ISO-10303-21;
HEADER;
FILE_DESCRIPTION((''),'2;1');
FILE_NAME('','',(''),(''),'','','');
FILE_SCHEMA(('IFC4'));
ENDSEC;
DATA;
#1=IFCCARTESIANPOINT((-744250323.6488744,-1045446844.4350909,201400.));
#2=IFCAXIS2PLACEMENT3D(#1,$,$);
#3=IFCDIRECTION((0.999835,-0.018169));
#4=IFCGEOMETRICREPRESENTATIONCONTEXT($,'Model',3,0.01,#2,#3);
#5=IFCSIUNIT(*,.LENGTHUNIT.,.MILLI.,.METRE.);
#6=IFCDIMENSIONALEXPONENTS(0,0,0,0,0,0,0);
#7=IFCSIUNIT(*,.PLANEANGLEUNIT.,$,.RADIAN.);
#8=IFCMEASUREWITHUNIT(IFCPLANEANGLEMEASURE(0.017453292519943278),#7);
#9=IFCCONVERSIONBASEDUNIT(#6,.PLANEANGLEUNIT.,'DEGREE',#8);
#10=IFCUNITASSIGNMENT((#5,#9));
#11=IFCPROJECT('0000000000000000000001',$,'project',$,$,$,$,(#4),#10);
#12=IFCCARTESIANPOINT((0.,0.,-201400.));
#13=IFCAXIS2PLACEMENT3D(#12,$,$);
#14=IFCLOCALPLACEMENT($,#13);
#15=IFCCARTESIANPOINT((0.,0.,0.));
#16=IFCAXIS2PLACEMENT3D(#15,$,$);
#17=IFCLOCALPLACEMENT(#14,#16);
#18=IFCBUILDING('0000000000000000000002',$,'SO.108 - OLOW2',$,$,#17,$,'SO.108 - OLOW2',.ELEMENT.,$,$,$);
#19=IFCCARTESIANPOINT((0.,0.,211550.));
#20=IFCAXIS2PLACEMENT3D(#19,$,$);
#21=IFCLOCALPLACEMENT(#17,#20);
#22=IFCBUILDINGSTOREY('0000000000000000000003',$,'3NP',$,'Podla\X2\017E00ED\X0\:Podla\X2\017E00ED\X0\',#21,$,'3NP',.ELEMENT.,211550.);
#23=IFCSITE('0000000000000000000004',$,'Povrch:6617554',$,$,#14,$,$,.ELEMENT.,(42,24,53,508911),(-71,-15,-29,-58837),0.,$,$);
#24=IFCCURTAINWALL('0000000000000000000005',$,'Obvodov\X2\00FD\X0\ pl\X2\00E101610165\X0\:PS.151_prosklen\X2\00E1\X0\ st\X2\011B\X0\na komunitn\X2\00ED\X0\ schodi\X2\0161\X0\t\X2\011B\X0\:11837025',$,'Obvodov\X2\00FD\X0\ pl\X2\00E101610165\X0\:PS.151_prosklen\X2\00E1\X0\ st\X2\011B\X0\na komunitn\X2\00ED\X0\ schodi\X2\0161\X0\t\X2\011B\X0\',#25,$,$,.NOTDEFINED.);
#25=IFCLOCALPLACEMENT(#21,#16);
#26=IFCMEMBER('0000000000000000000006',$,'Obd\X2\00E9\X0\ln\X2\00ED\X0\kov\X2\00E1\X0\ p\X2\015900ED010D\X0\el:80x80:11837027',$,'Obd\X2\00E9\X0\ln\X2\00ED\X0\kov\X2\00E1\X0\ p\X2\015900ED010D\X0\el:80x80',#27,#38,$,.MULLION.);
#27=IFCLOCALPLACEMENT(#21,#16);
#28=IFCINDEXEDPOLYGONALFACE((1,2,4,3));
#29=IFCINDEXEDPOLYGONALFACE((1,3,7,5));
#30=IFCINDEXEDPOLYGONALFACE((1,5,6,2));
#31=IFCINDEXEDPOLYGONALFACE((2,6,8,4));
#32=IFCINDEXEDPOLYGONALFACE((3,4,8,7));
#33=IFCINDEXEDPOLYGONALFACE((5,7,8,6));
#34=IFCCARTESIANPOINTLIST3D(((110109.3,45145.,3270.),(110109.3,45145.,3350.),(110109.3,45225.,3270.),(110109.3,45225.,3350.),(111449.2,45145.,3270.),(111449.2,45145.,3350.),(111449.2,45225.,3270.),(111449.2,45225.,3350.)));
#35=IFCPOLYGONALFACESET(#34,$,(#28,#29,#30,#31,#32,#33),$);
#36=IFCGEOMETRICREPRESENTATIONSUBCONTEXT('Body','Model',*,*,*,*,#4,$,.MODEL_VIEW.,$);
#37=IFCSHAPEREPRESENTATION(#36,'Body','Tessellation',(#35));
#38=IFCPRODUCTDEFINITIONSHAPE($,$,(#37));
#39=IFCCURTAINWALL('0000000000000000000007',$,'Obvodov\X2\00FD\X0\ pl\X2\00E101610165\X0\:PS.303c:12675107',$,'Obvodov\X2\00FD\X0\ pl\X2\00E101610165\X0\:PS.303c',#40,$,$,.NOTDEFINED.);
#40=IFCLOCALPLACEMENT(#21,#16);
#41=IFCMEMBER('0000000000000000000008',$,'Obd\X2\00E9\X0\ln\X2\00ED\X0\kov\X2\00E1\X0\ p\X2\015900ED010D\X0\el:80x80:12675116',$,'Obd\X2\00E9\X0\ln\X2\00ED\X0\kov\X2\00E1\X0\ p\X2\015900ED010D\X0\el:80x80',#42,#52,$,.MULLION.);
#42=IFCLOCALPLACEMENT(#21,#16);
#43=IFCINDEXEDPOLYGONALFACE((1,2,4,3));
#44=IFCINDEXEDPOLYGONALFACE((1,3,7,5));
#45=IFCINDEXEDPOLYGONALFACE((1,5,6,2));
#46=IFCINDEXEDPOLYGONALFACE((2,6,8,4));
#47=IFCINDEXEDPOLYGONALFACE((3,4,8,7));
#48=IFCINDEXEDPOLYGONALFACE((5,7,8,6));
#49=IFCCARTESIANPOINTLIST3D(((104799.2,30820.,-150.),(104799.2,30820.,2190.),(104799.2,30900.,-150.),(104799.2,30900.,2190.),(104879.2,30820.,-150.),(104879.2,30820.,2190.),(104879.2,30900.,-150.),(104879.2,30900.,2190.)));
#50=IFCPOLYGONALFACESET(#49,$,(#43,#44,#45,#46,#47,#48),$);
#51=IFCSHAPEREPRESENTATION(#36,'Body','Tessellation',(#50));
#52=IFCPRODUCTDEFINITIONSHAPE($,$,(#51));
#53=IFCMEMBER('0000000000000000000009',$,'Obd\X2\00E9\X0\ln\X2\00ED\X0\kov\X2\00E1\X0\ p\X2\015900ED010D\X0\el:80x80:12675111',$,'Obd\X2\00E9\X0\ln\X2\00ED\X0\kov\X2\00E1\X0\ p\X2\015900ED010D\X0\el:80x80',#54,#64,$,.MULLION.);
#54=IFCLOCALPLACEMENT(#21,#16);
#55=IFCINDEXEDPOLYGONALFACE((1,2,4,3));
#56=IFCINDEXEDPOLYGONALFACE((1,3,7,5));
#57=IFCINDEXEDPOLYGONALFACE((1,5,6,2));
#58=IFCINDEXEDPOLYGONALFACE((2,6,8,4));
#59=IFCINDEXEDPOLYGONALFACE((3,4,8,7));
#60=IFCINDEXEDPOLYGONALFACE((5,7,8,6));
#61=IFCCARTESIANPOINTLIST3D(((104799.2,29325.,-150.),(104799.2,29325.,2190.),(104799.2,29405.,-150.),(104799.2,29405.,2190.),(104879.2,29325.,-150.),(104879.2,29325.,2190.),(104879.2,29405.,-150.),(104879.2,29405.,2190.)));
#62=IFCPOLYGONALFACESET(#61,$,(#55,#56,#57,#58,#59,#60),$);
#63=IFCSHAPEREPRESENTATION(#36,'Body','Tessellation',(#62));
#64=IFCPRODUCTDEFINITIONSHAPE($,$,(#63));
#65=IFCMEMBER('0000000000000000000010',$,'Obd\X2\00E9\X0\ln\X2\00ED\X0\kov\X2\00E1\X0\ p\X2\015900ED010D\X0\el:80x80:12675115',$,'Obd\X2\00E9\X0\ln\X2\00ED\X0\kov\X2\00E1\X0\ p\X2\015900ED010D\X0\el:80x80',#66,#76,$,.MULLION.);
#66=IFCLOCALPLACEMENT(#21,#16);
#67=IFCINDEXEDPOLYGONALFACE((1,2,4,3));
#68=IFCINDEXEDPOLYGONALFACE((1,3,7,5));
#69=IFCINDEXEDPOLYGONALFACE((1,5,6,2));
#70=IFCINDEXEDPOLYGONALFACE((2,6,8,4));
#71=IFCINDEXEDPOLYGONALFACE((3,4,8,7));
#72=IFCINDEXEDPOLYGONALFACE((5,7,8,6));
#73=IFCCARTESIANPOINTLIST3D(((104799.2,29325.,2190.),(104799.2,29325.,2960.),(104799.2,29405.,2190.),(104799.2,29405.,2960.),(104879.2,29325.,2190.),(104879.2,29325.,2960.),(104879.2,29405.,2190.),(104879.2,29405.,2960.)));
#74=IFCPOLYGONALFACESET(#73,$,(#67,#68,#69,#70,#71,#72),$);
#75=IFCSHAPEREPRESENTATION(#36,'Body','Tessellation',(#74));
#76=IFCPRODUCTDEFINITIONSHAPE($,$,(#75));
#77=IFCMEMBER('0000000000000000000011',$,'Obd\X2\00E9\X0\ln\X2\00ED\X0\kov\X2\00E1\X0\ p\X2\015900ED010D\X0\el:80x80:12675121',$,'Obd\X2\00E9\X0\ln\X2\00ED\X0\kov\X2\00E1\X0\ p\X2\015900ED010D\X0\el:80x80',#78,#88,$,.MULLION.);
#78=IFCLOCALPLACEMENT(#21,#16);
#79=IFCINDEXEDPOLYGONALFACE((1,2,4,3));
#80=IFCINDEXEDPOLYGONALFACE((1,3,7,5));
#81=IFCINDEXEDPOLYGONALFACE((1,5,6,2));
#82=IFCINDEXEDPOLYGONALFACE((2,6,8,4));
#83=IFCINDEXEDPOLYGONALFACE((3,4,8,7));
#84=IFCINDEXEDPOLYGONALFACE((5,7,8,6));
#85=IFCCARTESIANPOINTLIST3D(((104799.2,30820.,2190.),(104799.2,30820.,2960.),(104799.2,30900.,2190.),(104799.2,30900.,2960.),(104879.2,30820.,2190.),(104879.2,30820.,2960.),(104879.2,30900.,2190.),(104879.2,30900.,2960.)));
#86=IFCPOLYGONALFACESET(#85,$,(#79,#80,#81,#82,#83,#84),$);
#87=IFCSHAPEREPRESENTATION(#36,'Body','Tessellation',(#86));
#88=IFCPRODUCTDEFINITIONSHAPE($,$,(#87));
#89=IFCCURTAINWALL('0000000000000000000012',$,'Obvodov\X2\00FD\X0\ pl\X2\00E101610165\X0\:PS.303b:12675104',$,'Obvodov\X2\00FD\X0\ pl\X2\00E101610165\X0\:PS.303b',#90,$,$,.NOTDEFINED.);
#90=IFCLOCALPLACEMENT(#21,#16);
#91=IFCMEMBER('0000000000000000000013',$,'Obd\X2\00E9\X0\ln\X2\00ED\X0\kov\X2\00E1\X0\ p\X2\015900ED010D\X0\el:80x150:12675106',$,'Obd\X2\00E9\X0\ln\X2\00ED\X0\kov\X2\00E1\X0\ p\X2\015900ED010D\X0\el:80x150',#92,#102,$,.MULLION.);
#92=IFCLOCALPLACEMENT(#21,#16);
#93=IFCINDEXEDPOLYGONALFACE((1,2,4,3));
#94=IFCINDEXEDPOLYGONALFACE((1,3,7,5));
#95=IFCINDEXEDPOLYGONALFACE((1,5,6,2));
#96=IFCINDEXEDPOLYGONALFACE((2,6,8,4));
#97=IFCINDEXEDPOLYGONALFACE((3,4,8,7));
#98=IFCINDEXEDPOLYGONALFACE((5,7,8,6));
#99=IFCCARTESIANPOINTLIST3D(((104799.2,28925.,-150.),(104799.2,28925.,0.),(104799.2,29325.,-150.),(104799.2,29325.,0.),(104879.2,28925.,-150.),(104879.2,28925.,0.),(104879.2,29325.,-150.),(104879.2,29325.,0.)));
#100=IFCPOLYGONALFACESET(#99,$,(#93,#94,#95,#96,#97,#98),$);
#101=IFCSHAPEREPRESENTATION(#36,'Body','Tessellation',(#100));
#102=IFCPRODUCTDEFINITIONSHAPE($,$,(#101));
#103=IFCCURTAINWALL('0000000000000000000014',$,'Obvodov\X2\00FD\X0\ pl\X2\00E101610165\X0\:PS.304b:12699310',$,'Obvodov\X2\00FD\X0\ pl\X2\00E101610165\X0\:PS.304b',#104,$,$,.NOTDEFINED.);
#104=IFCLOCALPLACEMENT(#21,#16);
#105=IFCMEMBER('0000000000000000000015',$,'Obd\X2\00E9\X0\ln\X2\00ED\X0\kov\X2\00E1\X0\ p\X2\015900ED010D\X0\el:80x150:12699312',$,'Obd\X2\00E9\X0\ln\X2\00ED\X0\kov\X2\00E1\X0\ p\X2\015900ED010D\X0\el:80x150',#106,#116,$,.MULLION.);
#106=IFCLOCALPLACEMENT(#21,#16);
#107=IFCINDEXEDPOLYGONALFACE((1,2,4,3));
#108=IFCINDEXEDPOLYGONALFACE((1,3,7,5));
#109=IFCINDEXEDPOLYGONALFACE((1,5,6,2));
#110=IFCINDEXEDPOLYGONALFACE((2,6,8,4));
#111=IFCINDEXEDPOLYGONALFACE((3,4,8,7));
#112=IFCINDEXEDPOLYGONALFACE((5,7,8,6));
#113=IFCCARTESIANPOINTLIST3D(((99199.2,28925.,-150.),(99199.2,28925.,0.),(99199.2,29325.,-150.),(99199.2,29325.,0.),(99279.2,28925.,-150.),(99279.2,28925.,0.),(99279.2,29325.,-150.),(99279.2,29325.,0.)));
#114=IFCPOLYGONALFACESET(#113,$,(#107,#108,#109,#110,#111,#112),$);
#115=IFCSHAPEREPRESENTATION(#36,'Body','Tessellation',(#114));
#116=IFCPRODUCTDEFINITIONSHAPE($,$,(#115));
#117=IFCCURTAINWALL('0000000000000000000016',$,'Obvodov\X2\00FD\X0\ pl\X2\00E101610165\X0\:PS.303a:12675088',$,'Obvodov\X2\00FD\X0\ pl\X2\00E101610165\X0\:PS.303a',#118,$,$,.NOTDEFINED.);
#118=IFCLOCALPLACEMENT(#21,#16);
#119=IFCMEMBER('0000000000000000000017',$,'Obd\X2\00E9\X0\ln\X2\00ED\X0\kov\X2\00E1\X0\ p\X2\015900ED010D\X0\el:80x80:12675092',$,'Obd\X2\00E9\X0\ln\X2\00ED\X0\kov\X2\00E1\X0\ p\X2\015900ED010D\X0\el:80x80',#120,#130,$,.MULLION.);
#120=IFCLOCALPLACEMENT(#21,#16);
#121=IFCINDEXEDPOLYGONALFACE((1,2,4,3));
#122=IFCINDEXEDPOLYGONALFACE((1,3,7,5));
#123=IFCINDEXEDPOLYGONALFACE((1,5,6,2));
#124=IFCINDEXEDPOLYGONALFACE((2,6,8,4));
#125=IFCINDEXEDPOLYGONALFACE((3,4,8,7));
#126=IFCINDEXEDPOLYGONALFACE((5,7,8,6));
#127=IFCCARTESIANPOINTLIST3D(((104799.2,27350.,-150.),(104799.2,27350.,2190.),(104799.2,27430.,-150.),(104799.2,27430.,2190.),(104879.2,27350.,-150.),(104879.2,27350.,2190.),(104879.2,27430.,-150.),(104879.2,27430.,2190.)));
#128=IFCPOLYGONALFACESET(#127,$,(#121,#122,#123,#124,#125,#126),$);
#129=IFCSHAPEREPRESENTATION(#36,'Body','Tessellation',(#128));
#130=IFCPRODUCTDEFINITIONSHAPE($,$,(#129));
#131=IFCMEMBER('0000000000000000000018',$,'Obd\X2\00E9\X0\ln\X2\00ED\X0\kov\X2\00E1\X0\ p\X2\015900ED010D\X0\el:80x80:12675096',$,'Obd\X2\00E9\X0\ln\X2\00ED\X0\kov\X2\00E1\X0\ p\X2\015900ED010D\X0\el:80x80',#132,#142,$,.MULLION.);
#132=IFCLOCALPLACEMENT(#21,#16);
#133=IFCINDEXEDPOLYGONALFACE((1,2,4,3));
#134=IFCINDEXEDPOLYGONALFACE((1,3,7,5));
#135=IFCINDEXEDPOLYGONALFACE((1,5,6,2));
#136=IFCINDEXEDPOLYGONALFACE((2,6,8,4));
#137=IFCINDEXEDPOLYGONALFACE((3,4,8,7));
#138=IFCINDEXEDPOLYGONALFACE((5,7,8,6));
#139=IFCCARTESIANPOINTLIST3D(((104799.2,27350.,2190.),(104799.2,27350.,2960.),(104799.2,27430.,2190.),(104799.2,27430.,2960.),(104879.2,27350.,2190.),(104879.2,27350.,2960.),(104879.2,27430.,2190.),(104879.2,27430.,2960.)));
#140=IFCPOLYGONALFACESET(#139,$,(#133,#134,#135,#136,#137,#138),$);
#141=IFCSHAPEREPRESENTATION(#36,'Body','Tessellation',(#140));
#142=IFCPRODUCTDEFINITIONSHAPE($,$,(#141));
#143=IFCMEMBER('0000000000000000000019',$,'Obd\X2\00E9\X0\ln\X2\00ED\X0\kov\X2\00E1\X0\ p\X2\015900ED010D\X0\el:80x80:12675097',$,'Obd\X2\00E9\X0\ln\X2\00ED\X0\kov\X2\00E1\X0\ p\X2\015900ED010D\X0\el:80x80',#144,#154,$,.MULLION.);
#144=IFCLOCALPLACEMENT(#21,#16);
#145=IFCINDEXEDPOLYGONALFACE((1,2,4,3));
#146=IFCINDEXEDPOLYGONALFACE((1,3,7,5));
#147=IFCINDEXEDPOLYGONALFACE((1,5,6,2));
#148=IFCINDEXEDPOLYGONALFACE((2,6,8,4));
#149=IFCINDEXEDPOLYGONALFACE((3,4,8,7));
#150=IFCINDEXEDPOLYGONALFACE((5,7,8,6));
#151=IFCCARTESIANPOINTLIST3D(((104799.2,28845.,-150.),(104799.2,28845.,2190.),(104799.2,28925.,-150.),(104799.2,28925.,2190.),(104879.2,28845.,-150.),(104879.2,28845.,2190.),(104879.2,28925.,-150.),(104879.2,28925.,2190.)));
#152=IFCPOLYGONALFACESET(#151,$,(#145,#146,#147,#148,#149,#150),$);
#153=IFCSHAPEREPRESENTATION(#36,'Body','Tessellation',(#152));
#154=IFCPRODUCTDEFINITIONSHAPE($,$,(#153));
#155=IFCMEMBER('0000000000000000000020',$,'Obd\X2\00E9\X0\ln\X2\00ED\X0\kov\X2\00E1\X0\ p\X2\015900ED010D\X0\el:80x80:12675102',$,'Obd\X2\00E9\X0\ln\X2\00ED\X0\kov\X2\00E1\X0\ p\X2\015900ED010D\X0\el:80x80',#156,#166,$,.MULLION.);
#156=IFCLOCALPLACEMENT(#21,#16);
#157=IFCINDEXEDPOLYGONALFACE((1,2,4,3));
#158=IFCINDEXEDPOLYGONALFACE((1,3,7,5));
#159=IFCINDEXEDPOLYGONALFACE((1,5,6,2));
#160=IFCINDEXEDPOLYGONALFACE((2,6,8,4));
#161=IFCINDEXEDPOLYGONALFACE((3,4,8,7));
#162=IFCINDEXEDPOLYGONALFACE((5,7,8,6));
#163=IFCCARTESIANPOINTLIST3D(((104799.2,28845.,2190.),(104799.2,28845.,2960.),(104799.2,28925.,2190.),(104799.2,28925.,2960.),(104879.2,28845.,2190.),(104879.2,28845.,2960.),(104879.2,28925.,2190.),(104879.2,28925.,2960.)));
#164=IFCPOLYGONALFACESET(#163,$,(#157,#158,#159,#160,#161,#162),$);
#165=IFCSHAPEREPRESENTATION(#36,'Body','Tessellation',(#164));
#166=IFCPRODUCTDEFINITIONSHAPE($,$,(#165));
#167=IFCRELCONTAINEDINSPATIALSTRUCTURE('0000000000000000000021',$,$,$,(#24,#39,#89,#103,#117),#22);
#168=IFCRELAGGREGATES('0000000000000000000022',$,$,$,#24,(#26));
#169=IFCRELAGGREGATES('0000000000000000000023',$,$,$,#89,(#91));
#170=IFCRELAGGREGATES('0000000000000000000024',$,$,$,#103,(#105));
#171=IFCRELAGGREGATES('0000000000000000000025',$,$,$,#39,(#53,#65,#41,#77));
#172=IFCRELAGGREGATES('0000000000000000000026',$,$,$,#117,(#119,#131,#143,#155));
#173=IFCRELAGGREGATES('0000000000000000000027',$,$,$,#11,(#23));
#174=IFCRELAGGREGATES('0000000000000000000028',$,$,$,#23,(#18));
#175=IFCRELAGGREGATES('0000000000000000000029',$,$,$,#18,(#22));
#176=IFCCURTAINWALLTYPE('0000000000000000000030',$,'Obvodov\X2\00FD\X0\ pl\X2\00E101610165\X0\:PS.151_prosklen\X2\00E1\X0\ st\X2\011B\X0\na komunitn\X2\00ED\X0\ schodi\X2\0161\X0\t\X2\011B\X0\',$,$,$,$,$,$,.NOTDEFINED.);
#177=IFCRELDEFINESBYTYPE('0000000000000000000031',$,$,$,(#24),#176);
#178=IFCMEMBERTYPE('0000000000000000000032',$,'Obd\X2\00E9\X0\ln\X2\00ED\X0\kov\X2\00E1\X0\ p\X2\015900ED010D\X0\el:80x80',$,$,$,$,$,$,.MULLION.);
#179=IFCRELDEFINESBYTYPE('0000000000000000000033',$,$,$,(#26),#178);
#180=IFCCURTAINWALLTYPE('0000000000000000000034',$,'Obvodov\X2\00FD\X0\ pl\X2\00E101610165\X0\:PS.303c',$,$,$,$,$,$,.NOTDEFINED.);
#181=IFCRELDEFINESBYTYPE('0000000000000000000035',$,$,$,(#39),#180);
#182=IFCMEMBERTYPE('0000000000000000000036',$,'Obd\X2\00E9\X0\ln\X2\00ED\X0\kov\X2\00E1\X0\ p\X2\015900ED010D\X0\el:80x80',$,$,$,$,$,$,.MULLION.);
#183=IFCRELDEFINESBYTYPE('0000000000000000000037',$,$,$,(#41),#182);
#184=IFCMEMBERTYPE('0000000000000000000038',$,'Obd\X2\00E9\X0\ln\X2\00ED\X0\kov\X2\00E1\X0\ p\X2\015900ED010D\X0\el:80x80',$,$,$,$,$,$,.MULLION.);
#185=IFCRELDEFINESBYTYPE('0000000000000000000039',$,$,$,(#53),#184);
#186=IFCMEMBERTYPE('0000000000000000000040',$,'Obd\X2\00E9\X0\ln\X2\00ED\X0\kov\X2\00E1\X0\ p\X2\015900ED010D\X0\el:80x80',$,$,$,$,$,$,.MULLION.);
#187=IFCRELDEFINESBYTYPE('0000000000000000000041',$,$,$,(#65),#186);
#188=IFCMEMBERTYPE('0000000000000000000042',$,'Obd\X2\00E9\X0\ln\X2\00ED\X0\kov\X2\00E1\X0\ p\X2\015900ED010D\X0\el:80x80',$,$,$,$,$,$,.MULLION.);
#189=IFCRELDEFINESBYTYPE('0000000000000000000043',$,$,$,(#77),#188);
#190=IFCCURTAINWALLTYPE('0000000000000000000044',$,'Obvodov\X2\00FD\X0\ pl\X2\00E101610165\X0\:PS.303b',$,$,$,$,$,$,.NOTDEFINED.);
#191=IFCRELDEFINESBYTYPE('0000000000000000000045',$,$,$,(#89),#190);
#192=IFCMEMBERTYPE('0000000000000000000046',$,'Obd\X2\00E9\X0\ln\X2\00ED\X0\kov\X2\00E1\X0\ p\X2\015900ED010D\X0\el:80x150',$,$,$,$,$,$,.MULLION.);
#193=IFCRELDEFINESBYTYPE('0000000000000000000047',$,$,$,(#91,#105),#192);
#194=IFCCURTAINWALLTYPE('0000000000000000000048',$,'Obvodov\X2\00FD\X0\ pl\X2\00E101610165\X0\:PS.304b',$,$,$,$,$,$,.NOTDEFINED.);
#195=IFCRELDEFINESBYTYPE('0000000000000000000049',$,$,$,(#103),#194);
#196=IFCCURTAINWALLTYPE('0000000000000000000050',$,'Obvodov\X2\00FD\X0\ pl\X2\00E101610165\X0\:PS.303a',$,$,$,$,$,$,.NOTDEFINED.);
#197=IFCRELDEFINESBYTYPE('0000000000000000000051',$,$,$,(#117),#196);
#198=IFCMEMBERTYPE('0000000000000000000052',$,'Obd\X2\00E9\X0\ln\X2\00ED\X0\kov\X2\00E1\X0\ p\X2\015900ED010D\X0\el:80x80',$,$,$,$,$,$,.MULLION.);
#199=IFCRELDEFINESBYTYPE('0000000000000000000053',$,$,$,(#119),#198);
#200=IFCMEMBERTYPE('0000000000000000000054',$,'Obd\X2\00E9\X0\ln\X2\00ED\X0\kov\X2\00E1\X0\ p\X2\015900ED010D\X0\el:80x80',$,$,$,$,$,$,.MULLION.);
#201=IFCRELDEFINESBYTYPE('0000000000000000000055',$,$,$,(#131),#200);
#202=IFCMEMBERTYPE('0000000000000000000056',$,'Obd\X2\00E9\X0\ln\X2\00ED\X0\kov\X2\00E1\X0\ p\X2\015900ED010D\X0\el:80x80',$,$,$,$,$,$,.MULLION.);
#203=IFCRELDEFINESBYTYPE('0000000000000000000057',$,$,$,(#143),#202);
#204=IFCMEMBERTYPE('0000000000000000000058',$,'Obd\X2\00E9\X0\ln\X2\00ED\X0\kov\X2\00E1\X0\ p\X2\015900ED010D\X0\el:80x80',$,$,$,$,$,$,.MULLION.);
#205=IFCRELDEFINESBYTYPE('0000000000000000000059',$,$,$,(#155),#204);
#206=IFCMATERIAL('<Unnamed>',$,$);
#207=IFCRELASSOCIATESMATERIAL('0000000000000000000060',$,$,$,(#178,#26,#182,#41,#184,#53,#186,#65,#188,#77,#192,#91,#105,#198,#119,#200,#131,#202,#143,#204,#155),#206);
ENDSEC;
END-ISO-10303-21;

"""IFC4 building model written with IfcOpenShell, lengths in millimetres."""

from ifc_helpers import new_model, entity, si_unit, converted_unit, direction, frame, origin, place, context, subcontext, project, spatial, indexed_curve, outline, extrude, source, transform, mapped, material, type_object, type_shapes, element, aggregate, save


model = new_model("IFC4")

# Units and contexts
model_context = context("Model", 3, precision=0.01, world=frame((-744250323.6488744, -1045446844.4350909, 201400.0)), true_north=direction((0.999835, -0.018169)))
body_context = subcontext(model_context, "Body", "Model", "MODEL_VIEW")
ifc_project = project(units=[si_unit("LENGTHUNIT", "METRE", prefix="MILLI"), converted_unit("PLANEANGLEUNIT", "DEGREE", entity("IfcPlaneAngleMeasure", 0.017453292519943278), si_unit("PLANEANGLEUNIT", "RADIAN"), dimensions=[0, 0, 0, 0, 0, 0, 0])], contexts=[model_context])

# Site, building, storey
site_placement = place(None, frame((0.0, 0.0, -201400.0)))
site = spatial("IfcSite", under=ifc_project, at=site_placement, Name="Povrch:6617554", CompositionType="ELEMENT", RefLatitude=(42, 24, 53, 508911), RefLongitude=(-71, -15, -29, -58837), RefElevation=0.0)
building_placement = place(site_placement, origin())
building = spatial("IfcBuilding", under=site, at=building_placement, Name="SO.108 - OLOW2", LongName="SO.108 - OLOW2", CompositionType="ELEMENT")
storey_placement = place(building_placement, frame((0.0, 0.0, 211550.0)))
storey = spatial("IfcBuildingStorey", under=building, at=storey_placement, Name="3NP", ObjectType="Podlaží:Podlaží", LongName="3NP", CompositionType="ELEMENT", Elevation=211550.0)

# Curtain wall, member
curtain_wall_type_1 = type_object("IfcCurtainWallType", Name="Obvodový plášť:PS.151_prosklená stěna komunitní schodiště", PredefinedType="NOTDEFINED")
curtain_wall_1_placement = place(storey_placement, frame((0.0, 0.0, -211550.0)))
curtain_wall_1 = element("IfcCurtainWall", 1, at=curtain_wall_1_placement, inside=storey, type_object=curtain_wall_type_1, Name="Obvodový plášť:PS.151_prosklená stěna komunitní schodiště:11837025", ObjectType="Obvodový plášť:PS.151_prosklená stěna komunitní schodiště", PredefinedType="NOTDEFINED")
ifc_material_1 = material(Name="<Unnamed>")
member_type_1 = type_object("IfcMemberType", Name="Obdélníková příčel:80x80", PredefinedType="MULLION", material=ifc_material_1)
shared_shape_1 = source(origin(), body_context, "Body", "SweptSolid", [
    extrude(outline(indexed_curve([(-40.0, -40.0), (40.0, -40.0), (40.0, 40.0), (-40.0, 40.0), (-40.0, -40.0)], self_intersect=False)), frame((-40.0, 0.0, -1339.9), z_axis=(0.0, 0.0, 1.0), x_axis=(-1.0, 0.0, 0.0)), (0.0, 0.0, 1.0), 1339.9),
])
type_shapes(member_type_1, [shared_shape_1])
member_1_placement = place(curtain_wall_1_placement, frame((111449.2, 45185.0, 214900.0), z_axis=(1.0, 0.0, 0.0), x_axis=(0.0, 0.0, 1.0)))
member_1 = element("IfcMember", 2, at=member_1_placement, type_object=member_type_1, material=ifc_material_1, Name="Obdélníková příčel:80x80:11837027", ObjectType="Obdélníková příčel:80x80", PredefinedType="MULLION", context=body_context, shape_type="MappedRepresentation", body=[
    mapped(shared_shape_1, transform((0.0, 0.0, 0.0), scale=1.0)),
])

# Curtain wall, members
curtain_wall_type_2 = type_object("IfcCurtainWallType", Name="Obvodový plášť:PS.303c", PredefinedType="NOTDEFINED")
curtain_wall_2_placement = place(storey_placement, frame((0.0, 0.0, -211550.0)))
curtain_wall_2 = element("IfcCurtainWall", 3, at=curtain_wall_2_placement, inside=storey, type_object=curtain_wall_type_2, Name="Obvodový plášť:PS.303c:12675107", ObjectType="Obvodový plášť:PS.303c", PredefinedType="NOTDEFINED")
member_type_2 = type_object("IfcMemberType", Name="Obdélníková příčel:80x80", PredefinedType="MULLION", material=ifc_material_1)
shared_shape_2 = source(origin(), body_context, "Body", "SweptSolid", [
    extrude(outline(indexed_curve([(-40.0, -40.0), (40.0, -40.0), (40.0, 40.0), (-40.0, 40.0), (-40.0, -40.0)], self_intersect=False)), frame((-40.0, 0.0, -2340.0), z_axis=(0.0, 0.0, 1.0), x_axis=(-1.0, 0.0, 0.0)), (0.0, 0.0, 1.0), 2340.0),
])
type_shapes(member_type_2, [shared_shape_2])
member_2_placement = place(curtain_wall_2_placement, frame((104839.2, 30900.0, 213740.0), z_axis=(0.0, 0.0, 1.0), x_axis=(0.0, 1.0, 0.0)))
member_2 = element("IfcMember", 4, at=member_2_placement, type_object=member_type_2, material=ifc_material_1, Name="Obdélníková příčel:80x80:12675116", ObjectType="Obdélníková příčel:80x80", PredefinedType="MULLION", context=body_context, shape_type="MappedRepresentation", body=[
    mapped(shared_shape_2, transform((0.0, 0.0, 0.0), scale=1.0)),
])
member_type_3 = type_object("IfcMemberType", Name="Obdélníková příčel:80x80", PredefinedType="MULLION", material=ifc_material_1)
shared_shape_3 = source(origin(), body_context, "Body", "SweptSolid", [
    extrude(outline(indexed_curve([(-40.0, -40.0), (40.0, -40.0), (40.0, 40.0), (-40.0, 40.0), (-40.0, -40.0)], self_intersect=False)), frame((-40.0, 0.0, -2340.0), z_axis=(0.0, 0.0, 1.0), x_axis=(-1.0, 0.0, 0.0)), (0.0, 0.0, 1.0), 2340.0),
])
type_shapes(member_type_3, [shared_shape_3])
member_3_placement = place(curtain_wall_2_placement, frame((104839.2, 29325.0, 211400.0), z_axis=(0.0, 0.0, -1.0), x_axis=(0.0, -1.0, 0.0)))
member_3 = element("IfcMember", 5, at=member_3_placement, type_object=member_type_3, material=ifc_material_1, Name="Obdélníková příčel:80x80:12675111", ObjectType="Obdélníková příčel:80x80", PredefinedType="MULLION", context=body_context, shape_type="MappedRepresentation", body=[
    mapped(shared_shape_3, transform((0.0, 0.0, 0.0), scale=1.0)),
])
member_type_4 = type_object("IfcMemberType", Name="Obdélníková příčel:80x80", PredefinedType="MULLION", material=ifc_material_1)
shared_shape_4 = source(origin(), body_context, "Body", "SweptSolid", [
    extrude(outline(indexed_curve([(-40.0, -40.0), (40.0, -40.0), (40.0, 40.0), (-40.0, 40.0), (-40.0, -40.0)], self_intersect=False)), frame((-40.0, 0.0, -770.0), z_axis=(0.0, 0.0, 1.0), x_axis=(-1.0, 0.0, 0.0)), (0.0, 0.0, 1.0), 770.0),
])
type_shapes(member_type_4, [shared_shape_4])
member_4_placement = place(curtain_wall_2_placement, frame((104839.2, 29325.0, 213740.0), z_axis=(0.0, 0.0, -1.0), x_axis=(0.0, -1.0, 0.0)))
member_4 = element("IfcMember", 6, at=member_4_placement, type_object=member_type_4, material=ifc_material_1, Name="Obdélníková příčel:80x80:12675115", ObjectType="Obdélníková příčel:80x80", PredefinedType="MULLION", context=body_context, shape_type="MappedRepresentation", body=[
    mapped(shared_shape_4, transform((0.0, 0.0, 0.0), scale=1.0)),
])
member_type_5 = type_object("IfcMemberType", Name="Obdélníková příčel:80x80", PredefinedType="MULLION", material=ifc_material_1)
shared_shape_5 = source(origin(), body_context, "Body", "SweptSolid", [
    extrude(outline(indexed_curve([(-40.0, -40.0), (40.0, -40.0), (40.0, 40.0), (-40.0, 40.0), (-40.0, -40.0)], self_intersect=False)), frame((-40.0, 0.0, -770.0), z_axis=(0.0, 0.0, 1.0), x_axis=(-1.0, 0.0, 0.0)), (0.0, 0.0, 1.0), 770.0),
])
type_shapes(member_type_5, [shared_shape_5])
member_5_placement = place(curtain_wall_2_placement, frame((104839.2, 30900.0, 214510.0), z_axis=(0.0, 0.0, 1.0), x_axis=(0.0, 1.0, 0.0)))
member_5 = element("IfcMember", 7, at=member_5_placement, type_object=member_type_5, material=ifc_material_1, Name="Obdélníková příčel:80x80:12675121", ObjectType="Obdélníková příčel:80x80", PredefinedType="MULLION", context=body_context, shape_type="MappedRepresentation", body=[
    mapped(shared_shape_5, transform((0.0, 0.0, 0.0), scale=1.0)),
])

# Curtain walls, members
curtain_wall_type_3 = type_object("IfcCurtainWallType", Name="Obvodový plášť:PS.303b", PredefinedType="NOTDEFINED")
curtain_wall_3_placement = place(storey_placement, frame((0.0, 0.0, -211550.0)))
curtain_wall_3 = element("IfcCurtainWall", 8, at=curtain_wall_3_placement, inside=storey, type_object=curtain_wall_type_3, Name="Obvodový plášť:PS.303b:12675104", ObjectType="Obvodový plášť:PS.303b", PredefinedType="NOTDEFINED")
member_type_6 = type_object("IfcMemberType", Name="Obdélníková příčel:80x150", PredefinedType="MULLION", material=ifc_material_1)
shared_shape_6 = source(origin(), body_context, "Body", "SweptSolid", [
    extrude(outline(indexed_curve([(-75.0, -40.0), (75.0, -40.0), (75.0, 40.0), (-75.0, 40.0), (-75.0, -40.0)], self_intersect=False)), frame((-75.0, 0.0, -400.0), z_axis=(0.0, 0.0, 1.0), x_axis=(-1.0, 0.0, 0.0)), (0.0, 0.0, 1.0), 400.0),
])
type_shapes(member_type_6, [shared_shape_6])
member_6_placement = place(curtain_wall_3_placement, frame((104839.2, 28925.0, 211400.0), z_axis=(0.0, -1.0, 0.0), x_axis=(0.0, 0.0, -1.0)))
member_6 = element("IfcMember", 9, at=member_6_placement, type_object=member_type_6, material=ifc_material_1, Name="Obdélníková příčel:80x150:12675106", ObjectType="Obdélníková příčel:80x150", PredefinedType="MULLION", context=body_context, shape_type="MappedRepresentation", body=[
    mapped(shared_shape_6, transform((0.0, 0.0, 0.0), scale=1.0)),
])
curtain_wall_type_4 = type_object("IfcCurtainWallType", Name="Obvodový plášť:PS.304b", PredefinedType="NOTDEFINED")
curtain_wall_4_placement = place(storey_placement, frame((0.0, 0.0, -211550.0)))
curtain_wall_4 = element("IfcCurtainWall", 10, at=curtain_wall_4_placement, inside=storey, type_object=curtain_wall_type_4, Name="Obvodový plášť:PS.304b:12699310", ObjectType="Obvodový plášť:PS.304b", PredefinedType="NOTDEFINED")
member_7_placement = place(curtain_wall_4_placement, frame((99239.2, 28925.0, 211400.0), z_axis=(0.0, -1.0, 0.0), x_axis=(0.0, 0.0, -1.0)))
member_7 = element("IfcMember", 11, at=member_7_placement, type_object=member_type_6, material=ifc_material_1, Name="Obdélníková příčel:80x150:12699312", ObjectType="Obdélníková příčel:80x150", PredefinedType="MULLION", context=body_context, shape_type="MappedRepresentation", body=[
    mapped(shared_shape_6, transform((0.0, 0.0, 0.0), scale=1.0)),
])

# Curtain wall, members
curtain_wall_type_5 = type_object("IfcCurtainWallType", Name="Obvodový plášť:PS.303a", PredefinedType="NOTDEFINED")
curtain_wall_5_placement = place(storey_placement, frame((0.0, 0.0, -211550.0)))
curtain_wall_5 = element("IfcCurtainWall", 12, at=curtain_wall_5_placement, inside=storey, type_object=curtain_wall_type_5, Name="Obvodový plášť:PS.303a:12675088", ObjectType="Obvodový plášť:PS.303a", PredefinedType="NOTDEFINED")
member_type_7 = type_object("IfcMemberType", Name="Obdélníková příčel:80x80", PredefinedType="MULLION", material=ifc_material_1)
shared_shape_7 = source(origin(), body_context, "Body", "SweptSolid", [
    extrude(outline(indexed_curve([(-40.0, -40.0), (40.0, -40.0), (40.0, 40.0), (-40.0, 40.0), (-40.0, -40.0)], self_intersect=False)), frame((-40.0, 0.0, -2340.0), z_axis=(0.0, 0.0, 1.0), x_axis=(-1.0, 0.0, 0.0)), (0.0, 0.0, 1.0), 2340.0),
])
type_shapes(member_type_7, [shared_shape_7])
member_8_placement = place(curtain_wall_5_placement, frame((104839.2, 27350.0, 211400.0), z_axis=(0.0, 0.0, -1.0), x_axis=(0.0, -1.0, 0.0)))
member_8 = element("IfcMember", 13, at=member_8_placement, type_object=member_type_7, material=ifc_material_1, Name="Obdélníková příčel:80x80:12675092", ObjectType="Obdélníková příčel:80x80", PredefinedType="MULLION", context=body_context, shape_type="MappedRepresentation", body=[
    mapped(shared_shape_7, transform((0.0, 0.0, 0.0), scale=1.0)),
])
member_type_8 = type_object("IfcMemberType", Name="Obdélníková příčel:80x80", PredefinedType="MULLION", material=ifc_material_1)
shared_shape_8 = source(origin(), body_context, "Body", "SweptSolid", [
    extrude(outline(indexed_curve([(-40.0, -40.0), (40.0, -40.0), (40.0, 40.0), (-40.0, 40.0), (-40.0, -40.0)], self_intersect=False)), frame((-40.0, 0.0, -770.0), z_axis=(0.0, 0.0, 1.0), x_axis=(-1.0, 0.0, 0.0)), (0.0, 0.0, 1.0), 770.0),
])
type_shapes(member_type_8, [shared_shape_8])
member_9_placement = place(curtain_wall_5_placement, frame((104839.2, 27350.0, 213740.0), z_axis=(0.0, 0.0, -1.0), x_axis=(0.0, -1.0, 0.0)))
member_9 = element("IfcMember", 14, at=member_9_placement, type_object=member_type_8, material=ifc_material_1, Name="Obdélníková příčel:80x80:12675096", ObjectType="Obdélníková příčel:80x80", PredefinedType="MULLION", context=body_context, shape_type="MappedRepresentation", body=[
    mapped(shared_shape_8, transform((0.0, 0.0, 0.0), scale=1.0)),
])
member_type_9 = type_object("IfcMemberType", Name="Obdélníková příčel:80x80", PredefinedType="MULLION", material=ifc_material_1)
shared_shape_9 = source(origin(), body_context, "Body", "SweptSolid", [
    extrude(outline(indexed_curve([(-40.0, -40.0), (40.0, -40.0), (40.0, 40.0), (-40.0, 40.0), (-40.0, -40.0)], self_intersect=False)), frame((-40.0, 0.0, -2340.0), z_axis=(0.0, 0.0, 1.0), x_axis=(-1.0, 0.0, 0.0)), (0.0, 0.0, 1.0), 2340.0),
])
type_shapes(member_type_9, [shared_shape_9])
member_10_placement = place(curtain_wall_5_placement, frame((104839.2, 28925.0, 213740.0), z_axis=(0.0, 0.0, 1.0), x_axis=(0.0, 1.0, 0.0)))
member_10 = element("IfcMember", 15, at=member_10_placement, type_object=member_type_9, material=ifc_material_1, Name="Obdélníková příčel:80x80:12675097", ObjectType="Obdélníková příčel:80x80", PredefinedType="MULLION", context=body_context, shape_type="MappedRepresentation", body=[
    mapped(shared_shape_9, transform((0.0, 0.0, 0.0), scale=1.0)),
])
member_type_10 = type_object("IfcMemberType", Name="Obdélníková příčel:80x80", PredefinedType="MULLION", material=ifc_material_1)
shared_shape_10 = source(origin(), body_context, "Body", "SweptSolid", [
    extrude(outline(indexed_curve([(-40.0, -40.0), (40.0, -40.0), (40.0, 40.0), (-40.0, 40.0), (-40.0, -40.0)], self_intersect=False)), frame((-40.0, 0.0, -770.0), z_axis=(0.0, 0.0, 1.0), x_axis=(-1.0, 0.0, 0.0)), (0.0, 0.0, 1.0), 770.0),
])
type_shapes(member_type_10, [shared_shape_10])
member_11_placement = place(curtain_wall_5_placement, frame((104839.2, 28925.0, 214510.0), z_axis=(0.0, 0.0, 1.0), x_axis=(0.0, 1.0, 0.0)))
member_11 = element("IfcMember", 16, at=member_11_placement, type_object=member_type_10, material=ifc_material_1, Name="Obdélníková příčel:80x80:12675102", ObjectType="Obdélníková příčel:80x80", PredefinedType="MULLION", context=body_context, shape_type="MappedRepresentation", body=[
    mapped(shared_shape_10, transform((0.0, 0.0, 0.0), scale=1.0)),
])

aggregate(curtain_wall_1, [member_1])
aggregate(curtain_wall_3, [member_6])
aggregate(curtain_wall_4, [member_7])
aggregate(curtain_wall_2, [member_3, member_4, member_2, member_5])

aggregate(curtain_wall_5, [member_8, member_9, member_10, member_11])

save(model, "model.ifc")
